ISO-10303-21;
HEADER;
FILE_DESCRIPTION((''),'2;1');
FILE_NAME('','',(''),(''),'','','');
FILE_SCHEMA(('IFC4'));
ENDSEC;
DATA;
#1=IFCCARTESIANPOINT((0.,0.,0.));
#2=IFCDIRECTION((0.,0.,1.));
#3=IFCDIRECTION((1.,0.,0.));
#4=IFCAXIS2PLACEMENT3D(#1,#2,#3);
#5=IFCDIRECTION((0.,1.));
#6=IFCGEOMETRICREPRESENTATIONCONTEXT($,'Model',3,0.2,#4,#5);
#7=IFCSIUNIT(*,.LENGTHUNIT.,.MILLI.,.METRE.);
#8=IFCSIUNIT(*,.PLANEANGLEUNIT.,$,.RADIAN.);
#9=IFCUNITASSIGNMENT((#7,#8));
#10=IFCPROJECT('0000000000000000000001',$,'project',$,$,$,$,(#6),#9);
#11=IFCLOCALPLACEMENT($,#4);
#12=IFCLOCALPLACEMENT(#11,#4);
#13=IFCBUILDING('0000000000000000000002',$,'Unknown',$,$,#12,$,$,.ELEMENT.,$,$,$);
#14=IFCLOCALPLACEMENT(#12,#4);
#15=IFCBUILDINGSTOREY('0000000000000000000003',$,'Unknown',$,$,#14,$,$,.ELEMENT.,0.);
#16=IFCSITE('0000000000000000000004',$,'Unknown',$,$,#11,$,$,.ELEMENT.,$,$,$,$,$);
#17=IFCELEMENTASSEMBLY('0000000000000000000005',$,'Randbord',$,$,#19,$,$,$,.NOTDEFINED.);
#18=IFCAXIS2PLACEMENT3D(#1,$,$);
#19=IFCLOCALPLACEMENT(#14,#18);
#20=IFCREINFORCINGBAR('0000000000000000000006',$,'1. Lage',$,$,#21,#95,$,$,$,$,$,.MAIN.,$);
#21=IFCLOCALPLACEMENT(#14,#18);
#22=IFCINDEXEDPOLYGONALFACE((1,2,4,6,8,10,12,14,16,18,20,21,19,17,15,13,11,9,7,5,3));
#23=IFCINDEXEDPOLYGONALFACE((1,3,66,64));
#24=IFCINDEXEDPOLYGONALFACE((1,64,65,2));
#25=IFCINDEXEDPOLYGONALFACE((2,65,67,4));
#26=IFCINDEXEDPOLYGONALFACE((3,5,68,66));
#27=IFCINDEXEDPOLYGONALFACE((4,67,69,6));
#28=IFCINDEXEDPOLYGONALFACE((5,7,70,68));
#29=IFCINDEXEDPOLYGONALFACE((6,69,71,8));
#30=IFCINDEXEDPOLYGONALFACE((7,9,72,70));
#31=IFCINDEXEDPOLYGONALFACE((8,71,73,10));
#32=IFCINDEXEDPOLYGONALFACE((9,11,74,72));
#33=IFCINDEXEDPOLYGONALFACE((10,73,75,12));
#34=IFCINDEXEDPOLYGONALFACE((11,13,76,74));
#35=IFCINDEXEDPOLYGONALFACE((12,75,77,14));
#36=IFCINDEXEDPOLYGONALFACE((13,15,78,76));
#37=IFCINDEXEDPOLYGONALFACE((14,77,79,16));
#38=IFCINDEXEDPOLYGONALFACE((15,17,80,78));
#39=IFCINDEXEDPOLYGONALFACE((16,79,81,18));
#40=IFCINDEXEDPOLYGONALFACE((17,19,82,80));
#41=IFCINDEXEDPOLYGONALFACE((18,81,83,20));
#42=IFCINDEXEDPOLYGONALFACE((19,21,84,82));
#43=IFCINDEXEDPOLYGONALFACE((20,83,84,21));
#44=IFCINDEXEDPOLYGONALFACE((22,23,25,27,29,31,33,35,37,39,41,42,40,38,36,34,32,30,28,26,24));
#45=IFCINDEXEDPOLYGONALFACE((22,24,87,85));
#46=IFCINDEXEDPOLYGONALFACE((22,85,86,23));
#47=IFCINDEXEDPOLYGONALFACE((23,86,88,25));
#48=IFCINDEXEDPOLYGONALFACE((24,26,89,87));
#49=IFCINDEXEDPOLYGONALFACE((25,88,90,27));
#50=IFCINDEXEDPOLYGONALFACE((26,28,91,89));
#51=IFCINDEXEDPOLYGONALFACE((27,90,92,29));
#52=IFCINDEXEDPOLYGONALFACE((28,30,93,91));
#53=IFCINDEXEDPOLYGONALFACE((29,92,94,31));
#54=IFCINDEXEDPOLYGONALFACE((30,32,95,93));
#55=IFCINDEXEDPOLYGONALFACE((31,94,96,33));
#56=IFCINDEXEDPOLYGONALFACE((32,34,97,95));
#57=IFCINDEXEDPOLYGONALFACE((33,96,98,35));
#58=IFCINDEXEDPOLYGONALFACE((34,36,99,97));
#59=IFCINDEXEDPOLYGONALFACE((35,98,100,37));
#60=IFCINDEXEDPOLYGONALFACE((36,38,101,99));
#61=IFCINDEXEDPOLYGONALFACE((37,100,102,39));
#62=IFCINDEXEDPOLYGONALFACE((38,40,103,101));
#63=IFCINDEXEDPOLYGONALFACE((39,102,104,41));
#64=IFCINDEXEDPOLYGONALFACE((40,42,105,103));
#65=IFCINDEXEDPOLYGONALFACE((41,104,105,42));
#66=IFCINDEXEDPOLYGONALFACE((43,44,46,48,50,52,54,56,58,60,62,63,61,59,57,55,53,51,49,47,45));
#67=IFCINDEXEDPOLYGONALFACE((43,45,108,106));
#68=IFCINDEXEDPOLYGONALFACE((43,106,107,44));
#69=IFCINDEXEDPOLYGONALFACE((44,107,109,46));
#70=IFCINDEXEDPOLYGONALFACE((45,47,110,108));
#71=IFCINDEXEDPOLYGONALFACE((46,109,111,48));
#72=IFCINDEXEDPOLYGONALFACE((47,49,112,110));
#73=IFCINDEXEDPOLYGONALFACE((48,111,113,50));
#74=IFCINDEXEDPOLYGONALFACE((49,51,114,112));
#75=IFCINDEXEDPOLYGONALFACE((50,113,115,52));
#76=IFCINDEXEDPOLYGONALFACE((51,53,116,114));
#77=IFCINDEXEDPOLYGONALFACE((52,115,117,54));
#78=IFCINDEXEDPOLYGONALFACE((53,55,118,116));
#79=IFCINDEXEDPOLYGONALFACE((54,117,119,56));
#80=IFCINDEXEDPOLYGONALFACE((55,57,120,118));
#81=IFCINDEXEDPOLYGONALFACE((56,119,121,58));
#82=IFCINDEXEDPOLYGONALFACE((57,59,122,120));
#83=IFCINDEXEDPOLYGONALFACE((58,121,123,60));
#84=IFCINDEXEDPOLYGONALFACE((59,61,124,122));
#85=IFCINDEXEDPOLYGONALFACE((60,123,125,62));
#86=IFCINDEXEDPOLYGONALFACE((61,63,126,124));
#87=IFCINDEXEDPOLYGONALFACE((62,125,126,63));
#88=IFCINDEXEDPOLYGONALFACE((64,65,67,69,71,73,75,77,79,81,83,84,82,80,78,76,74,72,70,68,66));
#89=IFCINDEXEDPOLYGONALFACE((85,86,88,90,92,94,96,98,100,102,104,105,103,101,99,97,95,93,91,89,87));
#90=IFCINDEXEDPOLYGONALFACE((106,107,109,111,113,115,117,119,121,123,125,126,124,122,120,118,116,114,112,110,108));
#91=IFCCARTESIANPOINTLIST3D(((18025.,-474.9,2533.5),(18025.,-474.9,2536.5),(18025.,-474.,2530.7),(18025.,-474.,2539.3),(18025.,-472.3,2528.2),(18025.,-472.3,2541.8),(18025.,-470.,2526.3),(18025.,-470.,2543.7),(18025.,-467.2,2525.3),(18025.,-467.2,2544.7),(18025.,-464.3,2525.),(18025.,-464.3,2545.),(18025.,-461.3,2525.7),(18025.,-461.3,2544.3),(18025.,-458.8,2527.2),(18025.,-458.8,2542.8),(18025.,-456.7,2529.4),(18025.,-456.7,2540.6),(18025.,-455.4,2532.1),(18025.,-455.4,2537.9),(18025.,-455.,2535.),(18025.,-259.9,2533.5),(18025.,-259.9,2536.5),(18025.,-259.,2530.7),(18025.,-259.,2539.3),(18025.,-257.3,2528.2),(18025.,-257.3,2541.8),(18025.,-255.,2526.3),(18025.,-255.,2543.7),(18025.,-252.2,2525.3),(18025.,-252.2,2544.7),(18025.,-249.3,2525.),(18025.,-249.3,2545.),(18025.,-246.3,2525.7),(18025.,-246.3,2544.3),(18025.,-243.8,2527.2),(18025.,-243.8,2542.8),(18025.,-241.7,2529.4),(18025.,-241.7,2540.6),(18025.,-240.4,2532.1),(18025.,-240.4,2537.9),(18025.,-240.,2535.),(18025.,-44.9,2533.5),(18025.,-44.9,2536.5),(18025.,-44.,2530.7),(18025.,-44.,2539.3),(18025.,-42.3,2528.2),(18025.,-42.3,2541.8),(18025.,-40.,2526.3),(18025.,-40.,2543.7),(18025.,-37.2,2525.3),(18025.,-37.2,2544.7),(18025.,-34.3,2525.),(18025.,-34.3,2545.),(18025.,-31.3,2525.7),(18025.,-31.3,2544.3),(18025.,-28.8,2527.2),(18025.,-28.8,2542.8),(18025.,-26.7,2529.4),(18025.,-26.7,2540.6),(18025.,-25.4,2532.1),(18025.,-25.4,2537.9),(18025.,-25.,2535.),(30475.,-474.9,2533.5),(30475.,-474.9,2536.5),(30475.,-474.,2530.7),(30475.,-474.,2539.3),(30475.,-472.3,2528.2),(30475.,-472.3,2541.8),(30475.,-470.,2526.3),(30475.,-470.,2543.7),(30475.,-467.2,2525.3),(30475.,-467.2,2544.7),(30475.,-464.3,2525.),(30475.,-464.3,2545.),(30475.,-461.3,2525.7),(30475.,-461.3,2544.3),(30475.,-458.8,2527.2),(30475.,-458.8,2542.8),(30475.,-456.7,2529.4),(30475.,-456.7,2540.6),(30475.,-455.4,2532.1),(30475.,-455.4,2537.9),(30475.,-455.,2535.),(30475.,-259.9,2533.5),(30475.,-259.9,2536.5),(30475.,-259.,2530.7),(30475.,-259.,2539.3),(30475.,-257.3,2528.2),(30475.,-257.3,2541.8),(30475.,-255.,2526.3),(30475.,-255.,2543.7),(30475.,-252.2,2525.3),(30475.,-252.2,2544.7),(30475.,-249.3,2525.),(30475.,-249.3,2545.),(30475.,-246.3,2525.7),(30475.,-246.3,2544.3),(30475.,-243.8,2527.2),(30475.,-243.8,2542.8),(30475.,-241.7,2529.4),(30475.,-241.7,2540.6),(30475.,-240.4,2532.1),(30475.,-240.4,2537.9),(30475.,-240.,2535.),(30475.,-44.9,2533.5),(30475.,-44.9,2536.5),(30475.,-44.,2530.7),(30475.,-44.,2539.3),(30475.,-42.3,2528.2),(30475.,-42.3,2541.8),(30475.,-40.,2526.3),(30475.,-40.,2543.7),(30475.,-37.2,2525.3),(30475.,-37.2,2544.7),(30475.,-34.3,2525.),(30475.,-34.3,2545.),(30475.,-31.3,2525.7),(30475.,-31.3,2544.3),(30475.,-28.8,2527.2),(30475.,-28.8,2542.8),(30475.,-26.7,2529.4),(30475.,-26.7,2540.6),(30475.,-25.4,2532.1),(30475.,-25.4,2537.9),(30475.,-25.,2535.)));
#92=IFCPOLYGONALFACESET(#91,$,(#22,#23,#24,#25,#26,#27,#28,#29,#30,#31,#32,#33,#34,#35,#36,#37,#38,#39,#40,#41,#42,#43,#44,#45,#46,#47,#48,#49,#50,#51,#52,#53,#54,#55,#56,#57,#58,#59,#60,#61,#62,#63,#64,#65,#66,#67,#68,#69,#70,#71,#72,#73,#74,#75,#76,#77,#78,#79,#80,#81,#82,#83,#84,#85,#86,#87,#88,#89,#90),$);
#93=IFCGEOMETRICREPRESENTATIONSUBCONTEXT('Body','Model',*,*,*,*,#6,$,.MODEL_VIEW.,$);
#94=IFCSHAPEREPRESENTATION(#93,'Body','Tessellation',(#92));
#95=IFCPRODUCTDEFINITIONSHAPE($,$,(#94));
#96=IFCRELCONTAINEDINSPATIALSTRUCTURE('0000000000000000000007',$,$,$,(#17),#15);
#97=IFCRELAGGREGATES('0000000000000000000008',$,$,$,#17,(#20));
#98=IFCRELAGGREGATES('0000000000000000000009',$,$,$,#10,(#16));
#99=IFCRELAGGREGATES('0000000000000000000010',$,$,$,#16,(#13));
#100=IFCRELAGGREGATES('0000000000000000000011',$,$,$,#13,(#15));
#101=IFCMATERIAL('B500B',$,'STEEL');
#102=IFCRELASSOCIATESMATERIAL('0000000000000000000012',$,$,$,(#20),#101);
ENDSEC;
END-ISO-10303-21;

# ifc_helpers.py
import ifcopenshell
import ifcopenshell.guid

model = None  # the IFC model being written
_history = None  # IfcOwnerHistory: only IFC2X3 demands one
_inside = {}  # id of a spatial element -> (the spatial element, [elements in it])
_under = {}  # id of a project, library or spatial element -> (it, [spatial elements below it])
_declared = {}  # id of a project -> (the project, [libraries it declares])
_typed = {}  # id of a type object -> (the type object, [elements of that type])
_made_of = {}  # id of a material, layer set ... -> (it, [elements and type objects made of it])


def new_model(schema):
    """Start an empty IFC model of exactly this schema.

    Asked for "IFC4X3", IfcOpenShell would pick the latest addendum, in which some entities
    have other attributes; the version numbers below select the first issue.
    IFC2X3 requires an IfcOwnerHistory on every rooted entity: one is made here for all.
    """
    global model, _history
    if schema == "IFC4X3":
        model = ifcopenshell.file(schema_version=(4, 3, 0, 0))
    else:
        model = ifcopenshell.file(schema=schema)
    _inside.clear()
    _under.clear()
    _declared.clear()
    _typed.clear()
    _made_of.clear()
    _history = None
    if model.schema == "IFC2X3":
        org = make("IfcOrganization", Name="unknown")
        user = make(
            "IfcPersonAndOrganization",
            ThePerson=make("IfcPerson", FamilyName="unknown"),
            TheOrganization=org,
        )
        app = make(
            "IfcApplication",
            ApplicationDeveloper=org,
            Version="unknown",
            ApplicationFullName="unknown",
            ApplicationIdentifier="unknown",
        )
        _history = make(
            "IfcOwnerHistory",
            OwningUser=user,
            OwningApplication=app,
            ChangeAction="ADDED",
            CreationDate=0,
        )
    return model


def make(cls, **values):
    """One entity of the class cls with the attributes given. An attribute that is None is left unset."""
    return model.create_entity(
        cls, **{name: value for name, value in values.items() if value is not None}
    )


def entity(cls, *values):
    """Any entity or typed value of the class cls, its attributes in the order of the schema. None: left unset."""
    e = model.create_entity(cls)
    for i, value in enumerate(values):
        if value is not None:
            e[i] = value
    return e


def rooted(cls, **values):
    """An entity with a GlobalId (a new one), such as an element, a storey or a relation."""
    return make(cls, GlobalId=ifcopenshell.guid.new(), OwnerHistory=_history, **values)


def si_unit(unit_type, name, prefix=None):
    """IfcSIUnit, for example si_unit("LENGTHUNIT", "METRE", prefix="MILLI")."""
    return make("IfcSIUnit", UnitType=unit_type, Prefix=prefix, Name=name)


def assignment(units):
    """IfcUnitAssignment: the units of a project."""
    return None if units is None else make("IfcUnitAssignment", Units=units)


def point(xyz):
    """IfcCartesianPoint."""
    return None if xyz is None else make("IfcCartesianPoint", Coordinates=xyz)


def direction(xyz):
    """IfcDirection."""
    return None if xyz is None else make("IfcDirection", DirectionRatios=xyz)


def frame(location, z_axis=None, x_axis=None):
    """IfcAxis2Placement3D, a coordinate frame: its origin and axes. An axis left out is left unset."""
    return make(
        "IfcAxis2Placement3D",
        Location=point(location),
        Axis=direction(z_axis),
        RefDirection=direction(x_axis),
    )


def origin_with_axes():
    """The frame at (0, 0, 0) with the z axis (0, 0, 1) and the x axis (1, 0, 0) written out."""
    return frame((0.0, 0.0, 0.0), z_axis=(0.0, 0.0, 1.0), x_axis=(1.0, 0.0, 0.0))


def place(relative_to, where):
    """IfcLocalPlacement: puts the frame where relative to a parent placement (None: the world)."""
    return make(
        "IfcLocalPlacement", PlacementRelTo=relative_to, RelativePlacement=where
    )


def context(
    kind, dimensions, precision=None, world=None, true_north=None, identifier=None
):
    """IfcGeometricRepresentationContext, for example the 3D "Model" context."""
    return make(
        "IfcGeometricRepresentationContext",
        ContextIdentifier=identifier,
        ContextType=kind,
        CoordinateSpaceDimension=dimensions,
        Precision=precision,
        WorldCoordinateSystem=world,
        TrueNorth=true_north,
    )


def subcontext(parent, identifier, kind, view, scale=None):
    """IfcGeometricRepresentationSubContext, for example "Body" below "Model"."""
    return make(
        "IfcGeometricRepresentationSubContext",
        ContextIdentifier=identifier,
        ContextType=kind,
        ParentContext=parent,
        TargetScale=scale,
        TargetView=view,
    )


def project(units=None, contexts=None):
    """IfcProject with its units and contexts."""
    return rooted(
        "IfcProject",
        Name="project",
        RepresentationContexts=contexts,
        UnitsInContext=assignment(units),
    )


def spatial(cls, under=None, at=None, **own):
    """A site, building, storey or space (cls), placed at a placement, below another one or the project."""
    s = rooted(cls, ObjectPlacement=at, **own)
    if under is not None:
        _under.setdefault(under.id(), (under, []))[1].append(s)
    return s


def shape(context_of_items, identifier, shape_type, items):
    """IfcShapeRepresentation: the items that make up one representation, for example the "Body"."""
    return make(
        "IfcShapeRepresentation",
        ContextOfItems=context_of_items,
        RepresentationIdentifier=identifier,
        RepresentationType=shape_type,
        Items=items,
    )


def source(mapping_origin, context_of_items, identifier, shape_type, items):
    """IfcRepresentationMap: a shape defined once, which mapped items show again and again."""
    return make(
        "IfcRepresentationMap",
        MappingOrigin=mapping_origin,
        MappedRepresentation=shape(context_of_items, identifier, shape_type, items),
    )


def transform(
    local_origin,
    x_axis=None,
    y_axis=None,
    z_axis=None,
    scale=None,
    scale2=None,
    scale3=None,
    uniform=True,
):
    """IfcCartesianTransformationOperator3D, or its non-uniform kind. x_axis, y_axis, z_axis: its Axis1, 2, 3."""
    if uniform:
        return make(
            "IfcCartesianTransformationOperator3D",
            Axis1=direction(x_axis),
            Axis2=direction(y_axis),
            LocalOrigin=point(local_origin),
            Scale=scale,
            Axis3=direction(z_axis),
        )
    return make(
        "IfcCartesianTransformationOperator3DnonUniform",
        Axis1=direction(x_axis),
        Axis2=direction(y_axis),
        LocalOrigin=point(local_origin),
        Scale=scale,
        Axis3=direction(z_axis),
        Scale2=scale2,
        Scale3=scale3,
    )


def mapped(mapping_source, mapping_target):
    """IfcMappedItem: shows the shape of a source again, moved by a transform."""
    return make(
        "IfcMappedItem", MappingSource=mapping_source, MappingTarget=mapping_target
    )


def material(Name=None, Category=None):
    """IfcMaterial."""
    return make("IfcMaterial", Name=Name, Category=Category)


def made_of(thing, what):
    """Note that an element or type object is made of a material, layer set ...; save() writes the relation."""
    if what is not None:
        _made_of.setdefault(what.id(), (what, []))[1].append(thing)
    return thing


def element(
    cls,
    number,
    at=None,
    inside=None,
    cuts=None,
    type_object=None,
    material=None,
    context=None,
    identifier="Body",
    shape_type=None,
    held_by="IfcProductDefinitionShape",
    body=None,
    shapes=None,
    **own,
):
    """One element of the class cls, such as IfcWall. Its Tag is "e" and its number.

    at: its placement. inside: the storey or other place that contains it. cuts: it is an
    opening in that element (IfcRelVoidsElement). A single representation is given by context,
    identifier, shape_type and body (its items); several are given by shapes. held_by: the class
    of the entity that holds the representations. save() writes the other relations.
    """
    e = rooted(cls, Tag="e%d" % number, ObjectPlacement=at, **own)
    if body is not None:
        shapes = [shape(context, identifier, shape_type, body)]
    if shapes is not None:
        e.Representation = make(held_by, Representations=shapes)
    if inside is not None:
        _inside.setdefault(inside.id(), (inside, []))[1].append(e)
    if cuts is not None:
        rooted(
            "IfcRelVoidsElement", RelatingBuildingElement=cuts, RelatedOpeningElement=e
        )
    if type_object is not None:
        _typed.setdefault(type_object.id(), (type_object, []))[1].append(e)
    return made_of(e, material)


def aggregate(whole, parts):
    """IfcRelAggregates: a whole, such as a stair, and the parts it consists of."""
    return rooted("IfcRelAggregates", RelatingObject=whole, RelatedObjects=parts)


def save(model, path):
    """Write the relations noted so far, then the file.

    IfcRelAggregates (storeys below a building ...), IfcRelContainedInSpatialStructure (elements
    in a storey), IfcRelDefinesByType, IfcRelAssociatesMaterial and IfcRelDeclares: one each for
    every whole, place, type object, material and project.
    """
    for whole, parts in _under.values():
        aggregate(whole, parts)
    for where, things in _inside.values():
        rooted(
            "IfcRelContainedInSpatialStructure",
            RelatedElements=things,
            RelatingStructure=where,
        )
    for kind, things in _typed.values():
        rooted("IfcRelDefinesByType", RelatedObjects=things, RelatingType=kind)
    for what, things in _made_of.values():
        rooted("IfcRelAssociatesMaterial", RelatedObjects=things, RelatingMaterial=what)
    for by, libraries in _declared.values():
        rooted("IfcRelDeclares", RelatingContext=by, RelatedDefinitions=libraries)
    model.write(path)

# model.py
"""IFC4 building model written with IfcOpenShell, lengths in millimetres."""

from ifc_helpers import new_model, entity, si_unit, direction, frame, origin_with_axes, place, context, subcontext, project, spatial, source, transform, mapped, material, element, aggregate, save


model = new_model("IFC4")

# Units and contexts
model_context = context("Model", 3, precision=0.2, world=origin_with_axes(), true_north=direction((0.0, 1.0)))
body_context = subcontext(model_context, "Body", "Model", "MODEL_VIEW")
ifc_project = project(units=[si_unit("LENGTHUNIT", "METRE", prefix="MILLI"), si_unit("PLANEANGLEUNIT", "RADIAN")], contexts=[model_context])

# Site, building, storey
site_placement = place(None, origin_with_axes())
site = spatial("IfcSite", under=ifc_project, at=site_placement, Name="Unknown", CompositionType="ELEMENT")
building_placement = place(site_placement, origin_with_axes())
building = spatial("IfcBuilding", under=site, at=building_placement, Name="Unknown", CompositionType="ELEMENT")
storey_placement = place(building_placement, origin_with_axes())
storey = spatial("IfcBuildingStorey", under=building, at=storey_placement, Name="Unknown", CompositionType="ELEMENT", Elevation=0.0)

# Element assembly, reinforcing bar
ifc_material_1 = material(Name="B500B", Category="STEEL")
assembly_1_placement = place(storey_placement, frame((30500.0, -250.0, 2950.0), z_axis=(0.0, 1.0, 0.0), x_axis=(-1.0, 0.0, 0.0)))
assembly_1 = element("IfcElementAssembly", 1, at=assembly_1_placement, inside=storey, Name="Randbord", PredefinedType="NOTDEFINED")
shared_shape_1 = source(origin_with_axes(), body_context, "Body", "AdvancedSweptSolid", [
    entity("IfcSweptDiskSolid", entity("IfcIndexedPolyCurve", entity("IfcCartesianPointList3D", [[0.0, 0.0, 0.0], [12450.0, 0.0, 0.0]]), [entity("IfcLineIndex", [1, 2])]), 10.0),
])
reinforcing_bar_1_placement = place(assembly_1_placement, frame((25.0, -415.0, -215.0), z_axis=(0.0, 0.0, 1.0), x_axis=(1.0, 0.0, 0.0)))
reinforcing_bar_1 = element("IfcReinforcingBar", 2, at=reinforcing_bar_1_placement, material=ifc_material_1, Name="1. Lage", PredefinedType="MAIN", context=body_context, shape_type="MappedRepresentation", body=[
    mapped(shared_shape_1, transform((0.0, 0.0, 0.0))),
    mapped(shared_shape_1, transform((0.0, 0.0, 215.0))),
    mapped(shared_shape_1, transform((0.0, 0.0, 430.0))),
])
aggregate(assembly_1, [reinforcing_bar_1])

save(model, "model.ifc")
